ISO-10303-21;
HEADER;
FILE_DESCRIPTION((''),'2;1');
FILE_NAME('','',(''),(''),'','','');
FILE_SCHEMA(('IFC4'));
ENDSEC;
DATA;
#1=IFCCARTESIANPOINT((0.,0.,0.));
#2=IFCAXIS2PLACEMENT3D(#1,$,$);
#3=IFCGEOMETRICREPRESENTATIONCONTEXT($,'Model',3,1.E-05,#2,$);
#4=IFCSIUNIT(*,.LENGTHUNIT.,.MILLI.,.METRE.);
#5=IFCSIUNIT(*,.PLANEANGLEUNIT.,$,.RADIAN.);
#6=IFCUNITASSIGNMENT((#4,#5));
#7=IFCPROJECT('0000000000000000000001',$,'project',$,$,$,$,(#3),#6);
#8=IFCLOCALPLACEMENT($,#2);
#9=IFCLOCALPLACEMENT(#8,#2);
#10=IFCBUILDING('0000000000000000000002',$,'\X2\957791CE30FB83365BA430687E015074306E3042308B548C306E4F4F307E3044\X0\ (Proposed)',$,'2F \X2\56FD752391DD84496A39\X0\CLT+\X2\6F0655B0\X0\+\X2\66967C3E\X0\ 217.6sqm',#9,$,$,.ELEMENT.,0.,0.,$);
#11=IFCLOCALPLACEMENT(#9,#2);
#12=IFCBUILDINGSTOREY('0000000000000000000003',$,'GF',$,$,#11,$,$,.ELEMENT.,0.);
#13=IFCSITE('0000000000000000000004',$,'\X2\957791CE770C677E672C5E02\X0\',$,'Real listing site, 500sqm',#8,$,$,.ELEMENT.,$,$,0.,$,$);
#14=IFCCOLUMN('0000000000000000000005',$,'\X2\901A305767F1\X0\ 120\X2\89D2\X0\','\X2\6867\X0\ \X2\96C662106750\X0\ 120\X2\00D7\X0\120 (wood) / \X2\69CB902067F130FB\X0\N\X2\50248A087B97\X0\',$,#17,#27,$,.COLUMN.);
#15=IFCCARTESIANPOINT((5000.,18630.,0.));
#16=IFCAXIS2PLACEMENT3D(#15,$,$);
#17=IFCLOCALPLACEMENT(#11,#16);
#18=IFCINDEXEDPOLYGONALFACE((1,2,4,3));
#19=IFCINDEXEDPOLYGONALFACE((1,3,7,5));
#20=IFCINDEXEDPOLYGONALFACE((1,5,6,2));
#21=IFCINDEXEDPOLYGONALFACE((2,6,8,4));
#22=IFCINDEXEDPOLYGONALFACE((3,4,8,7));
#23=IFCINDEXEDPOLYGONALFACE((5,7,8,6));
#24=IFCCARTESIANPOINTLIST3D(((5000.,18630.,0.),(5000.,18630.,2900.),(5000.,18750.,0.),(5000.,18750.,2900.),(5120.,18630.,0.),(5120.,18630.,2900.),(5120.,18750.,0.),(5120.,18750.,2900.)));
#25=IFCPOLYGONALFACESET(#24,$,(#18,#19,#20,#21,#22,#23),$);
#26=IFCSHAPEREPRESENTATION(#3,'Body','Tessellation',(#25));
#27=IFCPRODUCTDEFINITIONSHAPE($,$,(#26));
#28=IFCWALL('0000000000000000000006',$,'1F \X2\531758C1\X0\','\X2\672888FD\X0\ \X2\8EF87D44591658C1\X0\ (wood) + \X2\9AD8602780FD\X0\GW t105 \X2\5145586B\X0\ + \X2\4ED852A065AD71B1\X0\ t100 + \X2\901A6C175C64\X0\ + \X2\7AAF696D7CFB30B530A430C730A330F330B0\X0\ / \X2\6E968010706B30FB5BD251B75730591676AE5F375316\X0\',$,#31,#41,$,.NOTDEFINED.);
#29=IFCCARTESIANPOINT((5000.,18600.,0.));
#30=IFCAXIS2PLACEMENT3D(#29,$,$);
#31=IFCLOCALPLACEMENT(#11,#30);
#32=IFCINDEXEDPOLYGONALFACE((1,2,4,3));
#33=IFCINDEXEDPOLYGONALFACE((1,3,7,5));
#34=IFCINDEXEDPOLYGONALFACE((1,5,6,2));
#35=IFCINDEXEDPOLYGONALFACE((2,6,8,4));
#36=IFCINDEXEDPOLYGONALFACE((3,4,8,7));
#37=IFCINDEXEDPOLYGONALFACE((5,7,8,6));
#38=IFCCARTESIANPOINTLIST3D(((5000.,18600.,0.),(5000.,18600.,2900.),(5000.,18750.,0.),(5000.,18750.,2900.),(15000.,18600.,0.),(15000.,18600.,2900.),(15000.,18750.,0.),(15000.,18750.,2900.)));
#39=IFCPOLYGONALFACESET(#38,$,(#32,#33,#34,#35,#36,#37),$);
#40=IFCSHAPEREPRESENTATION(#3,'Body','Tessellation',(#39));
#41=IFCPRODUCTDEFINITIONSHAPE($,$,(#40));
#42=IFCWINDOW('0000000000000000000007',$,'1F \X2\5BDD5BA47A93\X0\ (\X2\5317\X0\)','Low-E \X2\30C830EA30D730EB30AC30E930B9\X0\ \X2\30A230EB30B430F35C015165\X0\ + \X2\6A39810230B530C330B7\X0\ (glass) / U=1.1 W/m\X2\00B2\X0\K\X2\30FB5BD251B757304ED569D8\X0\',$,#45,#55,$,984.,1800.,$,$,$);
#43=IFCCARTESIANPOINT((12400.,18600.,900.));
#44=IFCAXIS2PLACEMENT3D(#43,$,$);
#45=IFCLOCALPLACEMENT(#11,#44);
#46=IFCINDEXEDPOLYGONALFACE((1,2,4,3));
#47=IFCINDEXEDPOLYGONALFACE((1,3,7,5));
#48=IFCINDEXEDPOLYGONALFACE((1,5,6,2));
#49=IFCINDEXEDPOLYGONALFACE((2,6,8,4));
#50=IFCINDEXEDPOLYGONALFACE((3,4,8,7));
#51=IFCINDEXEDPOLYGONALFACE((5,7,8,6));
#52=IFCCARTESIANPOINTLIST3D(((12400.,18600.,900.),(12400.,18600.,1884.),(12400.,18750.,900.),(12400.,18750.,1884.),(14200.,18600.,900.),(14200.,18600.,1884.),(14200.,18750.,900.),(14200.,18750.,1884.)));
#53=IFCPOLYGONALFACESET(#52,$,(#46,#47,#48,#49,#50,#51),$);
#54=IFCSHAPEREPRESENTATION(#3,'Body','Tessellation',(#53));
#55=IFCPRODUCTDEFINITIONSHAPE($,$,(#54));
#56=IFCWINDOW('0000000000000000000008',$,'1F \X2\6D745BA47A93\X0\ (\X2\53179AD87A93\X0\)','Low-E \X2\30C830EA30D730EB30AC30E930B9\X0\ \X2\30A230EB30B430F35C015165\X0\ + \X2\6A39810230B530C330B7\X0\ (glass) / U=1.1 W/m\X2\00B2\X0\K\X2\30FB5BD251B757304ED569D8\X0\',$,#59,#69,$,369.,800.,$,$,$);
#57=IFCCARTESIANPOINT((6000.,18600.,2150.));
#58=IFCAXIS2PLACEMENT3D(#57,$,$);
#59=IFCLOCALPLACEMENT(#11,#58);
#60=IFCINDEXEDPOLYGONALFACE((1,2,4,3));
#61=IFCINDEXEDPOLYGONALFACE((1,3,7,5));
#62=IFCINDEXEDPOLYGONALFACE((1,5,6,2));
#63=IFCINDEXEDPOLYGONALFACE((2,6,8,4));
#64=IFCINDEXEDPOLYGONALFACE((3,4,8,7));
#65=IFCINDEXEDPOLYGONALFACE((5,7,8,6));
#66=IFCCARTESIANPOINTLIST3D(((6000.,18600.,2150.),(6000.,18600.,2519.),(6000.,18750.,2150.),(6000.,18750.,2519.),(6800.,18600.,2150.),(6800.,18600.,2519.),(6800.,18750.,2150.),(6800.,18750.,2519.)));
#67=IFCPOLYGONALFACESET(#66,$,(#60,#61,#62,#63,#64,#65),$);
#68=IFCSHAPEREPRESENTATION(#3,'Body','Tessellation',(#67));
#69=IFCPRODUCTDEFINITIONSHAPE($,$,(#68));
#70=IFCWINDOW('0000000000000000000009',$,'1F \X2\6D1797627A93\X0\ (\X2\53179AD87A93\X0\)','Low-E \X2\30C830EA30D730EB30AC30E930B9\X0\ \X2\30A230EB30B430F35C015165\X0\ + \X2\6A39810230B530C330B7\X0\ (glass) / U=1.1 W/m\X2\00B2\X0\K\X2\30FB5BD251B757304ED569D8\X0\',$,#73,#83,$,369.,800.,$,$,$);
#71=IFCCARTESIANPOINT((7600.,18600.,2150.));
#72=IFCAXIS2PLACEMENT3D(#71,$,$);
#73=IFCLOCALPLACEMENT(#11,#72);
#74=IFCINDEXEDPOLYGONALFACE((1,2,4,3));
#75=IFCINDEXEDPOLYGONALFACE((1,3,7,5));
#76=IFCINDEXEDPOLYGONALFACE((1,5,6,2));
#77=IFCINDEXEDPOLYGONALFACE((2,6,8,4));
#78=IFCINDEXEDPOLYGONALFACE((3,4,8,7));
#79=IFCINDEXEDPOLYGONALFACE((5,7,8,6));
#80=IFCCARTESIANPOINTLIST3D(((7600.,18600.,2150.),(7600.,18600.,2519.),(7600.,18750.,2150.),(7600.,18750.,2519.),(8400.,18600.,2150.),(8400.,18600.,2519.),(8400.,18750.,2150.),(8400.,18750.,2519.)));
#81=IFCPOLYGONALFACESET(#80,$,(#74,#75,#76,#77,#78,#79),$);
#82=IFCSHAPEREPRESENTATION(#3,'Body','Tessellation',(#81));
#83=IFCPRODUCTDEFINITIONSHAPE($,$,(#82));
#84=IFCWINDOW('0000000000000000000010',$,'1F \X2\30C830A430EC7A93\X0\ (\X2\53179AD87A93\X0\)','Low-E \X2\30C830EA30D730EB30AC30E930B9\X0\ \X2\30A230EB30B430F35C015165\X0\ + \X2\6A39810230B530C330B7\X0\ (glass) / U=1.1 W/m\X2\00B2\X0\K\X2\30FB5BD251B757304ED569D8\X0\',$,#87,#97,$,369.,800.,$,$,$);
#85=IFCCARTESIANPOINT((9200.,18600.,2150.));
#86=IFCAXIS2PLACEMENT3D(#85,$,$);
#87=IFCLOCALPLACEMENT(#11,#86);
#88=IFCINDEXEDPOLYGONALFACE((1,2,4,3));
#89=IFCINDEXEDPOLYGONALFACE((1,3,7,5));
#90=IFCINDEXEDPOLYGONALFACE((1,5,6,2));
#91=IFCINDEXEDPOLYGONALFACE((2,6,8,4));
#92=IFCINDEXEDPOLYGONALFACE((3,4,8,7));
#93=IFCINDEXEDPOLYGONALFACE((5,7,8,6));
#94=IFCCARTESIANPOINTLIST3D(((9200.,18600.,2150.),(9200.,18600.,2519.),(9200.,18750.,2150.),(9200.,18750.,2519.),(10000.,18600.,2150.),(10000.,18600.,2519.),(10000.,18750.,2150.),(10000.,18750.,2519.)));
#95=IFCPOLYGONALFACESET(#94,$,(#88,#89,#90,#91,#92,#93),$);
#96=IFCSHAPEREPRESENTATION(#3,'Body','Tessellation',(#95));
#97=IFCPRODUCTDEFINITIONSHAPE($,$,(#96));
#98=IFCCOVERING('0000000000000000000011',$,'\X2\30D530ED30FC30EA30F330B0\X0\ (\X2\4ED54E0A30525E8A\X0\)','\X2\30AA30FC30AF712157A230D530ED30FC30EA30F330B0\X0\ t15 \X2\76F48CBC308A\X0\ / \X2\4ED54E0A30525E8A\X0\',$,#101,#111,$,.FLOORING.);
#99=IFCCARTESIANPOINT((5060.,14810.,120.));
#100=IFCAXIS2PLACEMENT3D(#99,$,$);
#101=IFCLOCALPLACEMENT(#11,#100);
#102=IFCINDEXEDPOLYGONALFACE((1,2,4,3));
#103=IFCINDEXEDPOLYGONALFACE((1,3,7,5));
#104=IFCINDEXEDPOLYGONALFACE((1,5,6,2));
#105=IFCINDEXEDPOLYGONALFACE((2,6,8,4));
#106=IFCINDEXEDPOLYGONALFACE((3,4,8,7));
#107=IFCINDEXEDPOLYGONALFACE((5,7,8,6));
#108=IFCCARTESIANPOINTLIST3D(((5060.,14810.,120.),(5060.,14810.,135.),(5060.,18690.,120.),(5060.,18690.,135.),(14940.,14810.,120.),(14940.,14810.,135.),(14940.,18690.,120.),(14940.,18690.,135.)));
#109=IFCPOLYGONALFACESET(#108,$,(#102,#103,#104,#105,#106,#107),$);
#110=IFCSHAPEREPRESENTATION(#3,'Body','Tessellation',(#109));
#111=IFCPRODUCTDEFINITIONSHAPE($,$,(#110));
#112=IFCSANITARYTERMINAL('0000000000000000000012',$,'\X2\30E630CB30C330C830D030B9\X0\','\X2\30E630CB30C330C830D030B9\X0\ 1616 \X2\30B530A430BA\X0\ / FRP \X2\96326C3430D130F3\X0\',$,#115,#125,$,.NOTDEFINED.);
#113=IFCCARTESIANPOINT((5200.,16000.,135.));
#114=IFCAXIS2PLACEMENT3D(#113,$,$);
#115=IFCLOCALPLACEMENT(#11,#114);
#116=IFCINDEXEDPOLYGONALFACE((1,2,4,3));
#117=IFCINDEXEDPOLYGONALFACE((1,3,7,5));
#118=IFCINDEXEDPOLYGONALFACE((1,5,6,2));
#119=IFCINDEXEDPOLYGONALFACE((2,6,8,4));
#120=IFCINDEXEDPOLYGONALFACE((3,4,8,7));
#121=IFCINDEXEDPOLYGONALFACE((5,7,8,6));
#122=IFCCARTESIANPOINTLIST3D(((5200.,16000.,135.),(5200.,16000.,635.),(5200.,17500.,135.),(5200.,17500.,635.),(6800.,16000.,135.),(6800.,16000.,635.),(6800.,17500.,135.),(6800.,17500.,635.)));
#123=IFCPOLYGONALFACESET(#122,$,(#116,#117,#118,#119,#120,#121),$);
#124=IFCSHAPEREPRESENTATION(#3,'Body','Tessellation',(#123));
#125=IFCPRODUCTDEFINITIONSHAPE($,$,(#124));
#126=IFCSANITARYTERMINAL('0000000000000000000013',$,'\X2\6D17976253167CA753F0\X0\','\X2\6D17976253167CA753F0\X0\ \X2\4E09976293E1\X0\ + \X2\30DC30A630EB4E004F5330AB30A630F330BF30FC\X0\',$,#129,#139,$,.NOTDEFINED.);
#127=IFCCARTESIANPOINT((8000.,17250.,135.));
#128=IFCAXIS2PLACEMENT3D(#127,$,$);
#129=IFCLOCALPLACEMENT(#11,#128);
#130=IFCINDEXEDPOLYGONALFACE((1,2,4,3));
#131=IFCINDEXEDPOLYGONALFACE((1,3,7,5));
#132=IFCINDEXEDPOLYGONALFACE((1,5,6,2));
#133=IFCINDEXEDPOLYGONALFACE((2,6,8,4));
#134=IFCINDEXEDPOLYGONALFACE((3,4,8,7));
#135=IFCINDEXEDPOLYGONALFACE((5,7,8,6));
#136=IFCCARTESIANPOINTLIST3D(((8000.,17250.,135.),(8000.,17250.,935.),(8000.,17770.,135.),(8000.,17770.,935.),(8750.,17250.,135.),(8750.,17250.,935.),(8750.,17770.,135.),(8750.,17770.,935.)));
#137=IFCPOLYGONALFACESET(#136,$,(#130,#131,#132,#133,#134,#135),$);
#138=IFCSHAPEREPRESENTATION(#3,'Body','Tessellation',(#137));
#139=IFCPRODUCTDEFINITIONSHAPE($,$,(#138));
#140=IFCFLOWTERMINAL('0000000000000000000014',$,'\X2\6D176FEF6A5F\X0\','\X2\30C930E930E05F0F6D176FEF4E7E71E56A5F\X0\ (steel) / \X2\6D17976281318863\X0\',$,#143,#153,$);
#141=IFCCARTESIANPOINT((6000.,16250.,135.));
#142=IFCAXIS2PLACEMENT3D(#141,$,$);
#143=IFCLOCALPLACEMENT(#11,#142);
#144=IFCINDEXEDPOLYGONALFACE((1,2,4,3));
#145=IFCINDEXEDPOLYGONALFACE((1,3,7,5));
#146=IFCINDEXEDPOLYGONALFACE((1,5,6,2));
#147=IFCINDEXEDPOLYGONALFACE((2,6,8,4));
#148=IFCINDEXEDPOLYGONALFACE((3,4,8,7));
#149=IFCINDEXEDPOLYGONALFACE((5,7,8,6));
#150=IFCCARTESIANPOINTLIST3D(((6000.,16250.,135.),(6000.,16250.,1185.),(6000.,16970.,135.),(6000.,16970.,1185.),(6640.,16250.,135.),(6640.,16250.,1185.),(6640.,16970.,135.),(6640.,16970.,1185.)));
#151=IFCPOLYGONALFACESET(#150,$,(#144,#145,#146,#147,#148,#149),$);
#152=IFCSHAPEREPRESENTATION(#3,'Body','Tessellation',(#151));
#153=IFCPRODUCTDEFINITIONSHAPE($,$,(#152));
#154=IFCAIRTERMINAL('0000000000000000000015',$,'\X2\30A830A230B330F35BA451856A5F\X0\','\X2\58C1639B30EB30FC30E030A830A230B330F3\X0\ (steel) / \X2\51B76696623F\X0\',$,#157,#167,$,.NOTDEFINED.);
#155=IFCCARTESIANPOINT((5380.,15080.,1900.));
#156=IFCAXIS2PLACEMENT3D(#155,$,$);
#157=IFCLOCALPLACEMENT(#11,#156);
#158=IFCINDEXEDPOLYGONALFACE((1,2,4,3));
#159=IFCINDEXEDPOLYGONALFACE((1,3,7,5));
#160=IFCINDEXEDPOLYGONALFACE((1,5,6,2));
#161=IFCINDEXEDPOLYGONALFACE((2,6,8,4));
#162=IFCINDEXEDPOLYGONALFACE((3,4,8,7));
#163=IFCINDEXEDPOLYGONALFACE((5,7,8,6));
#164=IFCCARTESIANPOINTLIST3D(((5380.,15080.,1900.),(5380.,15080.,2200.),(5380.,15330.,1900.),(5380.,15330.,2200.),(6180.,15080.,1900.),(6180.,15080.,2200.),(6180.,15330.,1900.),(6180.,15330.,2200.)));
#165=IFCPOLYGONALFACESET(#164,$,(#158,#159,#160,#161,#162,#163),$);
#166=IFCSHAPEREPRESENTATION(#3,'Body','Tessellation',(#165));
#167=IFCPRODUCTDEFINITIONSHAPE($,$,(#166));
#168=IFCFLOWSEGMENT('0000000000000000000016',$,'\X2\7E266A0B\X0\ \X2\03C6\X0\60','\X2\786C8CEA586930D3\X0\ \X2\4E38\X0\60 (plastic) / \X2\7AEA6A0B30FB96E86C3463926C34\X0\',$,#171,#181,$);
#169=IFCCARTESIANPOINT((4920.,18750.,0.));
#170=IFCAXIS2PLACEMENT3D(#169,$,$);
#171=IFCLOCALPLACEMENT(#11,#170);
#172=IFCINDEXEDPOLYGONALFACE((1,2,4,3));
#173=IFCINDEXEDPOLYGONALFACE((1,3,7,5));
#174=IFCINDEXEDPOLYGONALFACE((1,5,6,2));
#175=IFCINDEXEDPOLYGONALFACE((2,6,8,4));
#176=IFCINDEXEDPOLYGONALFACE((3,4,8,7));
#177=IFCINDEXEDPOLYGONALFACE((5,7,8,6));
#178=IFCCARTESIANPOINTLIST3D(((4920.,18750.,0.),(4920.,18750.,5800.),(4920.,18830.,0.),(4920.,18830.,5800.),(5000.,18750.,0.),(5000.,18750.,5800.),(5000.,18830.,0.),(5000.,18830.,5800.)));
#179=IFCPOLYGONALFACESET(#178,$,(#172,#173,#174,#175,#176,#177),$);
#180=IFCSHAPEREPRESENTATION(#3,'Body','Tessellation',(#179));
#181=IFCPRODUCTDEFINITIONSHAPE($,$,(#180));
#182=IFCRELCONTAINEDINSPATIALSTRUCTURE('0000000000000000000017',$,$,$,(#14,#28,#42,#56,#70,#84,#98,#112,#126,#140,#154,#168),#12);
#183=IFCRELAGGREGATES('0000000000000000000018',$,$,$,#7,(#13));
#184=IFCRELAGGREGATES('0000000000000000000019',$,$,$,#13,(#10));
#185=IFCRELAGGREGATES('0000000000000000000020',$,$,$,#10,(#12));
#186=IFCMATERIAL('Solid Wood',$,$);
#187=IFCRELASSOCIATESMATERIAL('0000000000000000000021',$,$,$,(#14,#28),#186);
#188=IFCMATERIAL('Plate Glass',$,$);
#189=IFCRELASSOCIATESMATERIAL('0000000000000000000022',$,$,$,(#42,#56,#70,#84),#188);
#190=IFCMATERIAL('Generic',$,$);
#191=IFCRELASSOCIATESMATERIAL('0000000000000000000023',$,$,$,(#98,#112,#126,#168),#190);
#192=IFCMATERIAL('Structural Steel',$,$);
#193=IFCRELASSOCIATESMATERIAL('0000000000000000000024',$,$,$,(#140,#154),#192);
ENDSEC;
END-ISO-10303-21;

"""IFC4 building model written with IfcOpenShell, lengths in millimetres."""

from ifc_helpers import new_model, si_unit, frame, frame_2d, origin, place, context, project, spatial, rectangle, extrude, material, element, fill, save


model = new_model("IFC4")

# Units and contexts
model_context = context("Model", 3, precision=1e-05, world=origin())
ifc_project = project(units=[si_unit("LENGTHUNIT", "METRE", prefix="MILLI"), si_unit("PLANEANGLEUNIT", "RADIAN")], contexts=[model_context])

# Site, building, storey
site_placement = place(None, origin())
site = spatial("IfcSite", under=ifc_project, at=site_placement, Name="長野県松本市", ObjectType="Real listing site, 500sqm", CompositionType="ELEMENT", RefElevation=0.0)
building_placement = place(site_placement, origin())
building = spatial("IfcBuilding", under=site, at=building_placement, Name="長野・茶室と縁側のある和の住まい (Proposed)", ObjectType="2F 国産針葉樹CLT+漆喰+暖簾 217.6sqm", CompositionType="ELEMENT", ElevationOfRefHeight=0.0, ElevationOfTerrain=0.0)
storey_placement = place(building_placement, origin())
storey = spatial("IfcBuildingStorey", under=building, at=storey_placement, Name="GF", CompositionType="ELEMENT", Elevation=0.0)

# Column
ifc_material_1 = material(Name="Solid Wood")
column_1_placement = place(storey_placement, frame((5000.0, 18630.0, 0.0)))
element("IfcColumn", 1, at=column_1_placement, inside=storey, material=ifc_material_1, Name="通し柱 120角", Description="桧 集成材 120×120 (wood) / 構造柱・N値計算", PredefinedType="COLUMN", context=model_context, shape_type="SweptSolid", body=[
    extrude(rectangle(XDim=120.0, YDim=120.0, at=frame_2d((60.0, 60.0))), frame((5000.0, 18630.0, 0.0)), (0.0, 0.0, 1.0), 2900.0),
])

# Wall, openings, windows
wall_1_placement = place(storey_placement, frame((5000.0, 18600.0, 0.0)))
wall_1 = element("IfcWall", 2, at=wall_1_placement, inside=storey, material=ifc_material_1, Name="1F 北壁", Description="木製 軸組外壁 (wood) + 高性能GW t105 充填 + 付加断熱 t100 + 通気層 + 窯業系サイディング / 準耐火・寒冷地外皮強化", PredefinedType="NOTDEFINED", context=model_context, shape_type="SweptSolid", body=[
    extrude(rectangle(XDim=10000.0, YDim=150.0, at=frame_2d((5000.0, 75.0))), frame((5000.0, 18600.0, 0.0)), (0.0, 0.0, 1.0), 2900.0),
])
opening_1_placement = place(storey_placement, frame((12400.0, 18600.0, 900.0)))
opening_1 = element("IfcOpeningElement", 3, at=opening_1_placement, cuts=wall_1, PredefinedType="NOTDEFINED", context=model_context, shape_type="SweptSolid", body=[
    extrude(rectangle(XDim=1800.0, YDim=150.0, at=frame_2d((900.0, 75.0))), frame((12400.0, 18600.0, 900.0)), (0.0, 0.0, 1.0), 984.0),
])
opening_2_placement = place(storey_placement, frame((6000.0, 18600.0, 2150.0)))
opening_2 = element("IfcOpeningElement", 4, at=opening_2_placement, cuts=wall_1, PredefinedType="NOTDEFINED", context=model_context, shape_type="SweptSolid", body=[
    extrude(rectangle(XDim=800.0, YDim=150.0, at=frame_2d((400.0, 75.0))), frame((6000.0, 18600.0, 2150.0)), (0.0, 0.0, 1.0), 369.0),
])
opening_3_placement = place(storey_placement, frame((7600.0, 18600.0, 2150.0)))
opening_3 = element("IfcOpeningElement", 5, at=opening_3_placement, cuts=wall_1, PredefinedType="NOTDEFINED", context=model_context, shape_type="SweptSolid", body=[
    extrude(rectangle(XDim=800.0, YDim=150.0, at=frame_2d((400.0, 75.0))), frame((7600.0, 18600.0, 2150.0)), (0.0, 0.0, 1.0), 369.0),
])
opening_4_placement = place(storey_placement, frame((9200.0, 18600.0, 2150.0)))
opening_4 = element("IfcOpeningElement", 6, at=opening_4_placement, cuts=wall_1, PredefinedType="NOTDEFINED", context=model_context, shape_type="SweptSolid", body=[
    extrude(rectangle(XDim=800.0, YDim=150.0, at=frame_2d((400.0, 75.0))), frame((9200.0, 18600.0, 2150.0)), (0.0, 0.0, 1.0), 369.0),
])
ifc_material_2 = material(Name="Plate Glass")
window_1_placement = place(storey_placement, frame((12400.0, 18600.0, 900.0)))
window_1 = element("IfcWindow", 7, at=window_1_placement, inside=storey, material=ifc_material_2, Name="1F 寝室窓 (北)", Description="Low-E トリプルガラス アルゴン封入 + 樹脂サッシ (glass) / U=1.1 W/m²K・寒冷地仕様", OverallHeight=984.0, OverallWidth=1800.0, context=model_context, shape_type="SweptSolid", body=[
    extrude(rectangle(XDim=1800.0, YDim=150.0, at=frame_2d((900.0, 75.0))), frame((12400.0, 18600.0, 900.0)), (0.0, 0.0, 1.0), 984.0),
])
fill(opening_1, window_1)
window_2_placement = place(storey_placement, frame((6000.0, 18600.0, 2150.0)))
window_2 = element("IfcWindow", 8, at=window_2_placement, inside=storey, material=ifc_material_2, Name="1F 浴室窓 (北高窓)", Description="Low-E トリプルガラス アルゴン封入 + 樹脂サッシ (glass) / U=1.1 W/m²K・寒冷地仕様", OverallHeight=369.0, OverallWidth=800.0, context=model_context, shape_type="SweptSolid", body=[
    extrude(rectangle(XDim=800.0, YDim=150.0, at=frame_2d((400.0, 75.0))), frame((6000.0, 18600.0, 2150.0)), (0.0, 0.0, 1.0), 369.0),
])
fill(opening_2, window_2)
window_3_placement = place(storey_placement, frame((7600.0, 18600.0, 2150.0)))
window_3 = element("IfcWindow", 9, at=window_3_placement, inside=storey, material=ifc_material_2, Name="1F 洗面窓 (北高窓)", Description="Low-E トリプルガラス アルゴン封入 + 樹脂サッシ (glass) / U=1.1 W/m²K・寒冷地仕様", OverallHeight=369.0, OverallWidth=800.0, context=model_context, shape_type="SweptSolid", body=[
    extrude(rectangle(XDim=800.0, YDim=150.0, at=frame_2d((400.0, 75.0))), frame((7600.0, 18600.0, 2150.0)), (0.0, 0.0, 1.0), 369.0),
])
fill(opening_3, window_3)
window_4_placement = place(storey_placement, frame((9200.0, 18600.0, 2150.0)))
window_4 = element("IfcWindow", 10, at=window_4_placement, inside=storey, material=ifc_material_2, Name="1F トイレ窓 (北高窓)", Description="Low-E トリプルガラス アルゴン封入 + 樹脂サッシ (glass) / U=1.1 W/m²K・寒冷地仕様", OverallHeight=369.0, OverallWidth=800.0, context=model_context, shape_type="SweptSolid", body=[
    extrude(rectangle(XDim=800.0, YDim=150.0, at=frame_2d((400.0, 75.0))), frame((9200.0, 18600.0, 2150.0)), (0.0, 0.0, 1.0), 369.0),
])
fill(opening_4, window_4)

# Covering
ifc_material_3 = material(Name="Generic")
covering_placement = place(storey_placement, frame((5060.0, 14810.0, 120.0)))
element("IfcCovering", 11, at=covering_placement, inside=storey, material=ifc_material_3, Name="フローリング (仕上げ床)", Description="オーク無垢フローリング t15 直貼り / 仕上げ床", PredefinedType="FLOORING", context=model_context, shape_type="SweptSolid", body=[
    extrude(rectangle(XDim=9880.0, YDim=3880.0, at=frame_2d((4940.0, 1940.0))), frame((5060.0, 14810.0, 120.0)), (0.0, 0.0, 1.0), 15.0),
])

# Sanitary terminals
sanitary_terminal_1_placement = place(storey_placement, frame((5200.0, 16000.0, 135.0)))
element("IfcSanitaryTerminal", 12, at=sanitary_terminal_1_placement, inside=storey, material=ifc_material_3, Name="ユニットバス", Description="ユニットバス 1616 サイズ / FRP 防水パン", PredefinedType="NOTDEFINED", context=model_context, shape_type="SweptSolid", body=[
    extrude(rectangle(XDim=1600.0, YDim=1500.0, at=frame_2d((800.0, 750.0))), frame((5200.0, 16000.0, 135.0)), (0.0, 0.0, 1.0), 500.0),
])
sanitary_terminal_2_placement = place(storey_placement, frame((8000.0, 17250.0, 135.0)))
element("IfcSanitaryTerminal", 13, at=sanitary_terminal_2_placement, inside=storey, material=ifc_material_3, Name="洗面化粧台", Description="洗面化粧台 三面鏡 + ボウル一体カウンター", PredefinedType="NOTDEFINED", context=model_context, shape_type="SweptSolid", body=[
    extrude(rectangle(XDim=750.0, YDim=520.0, at=frame_2d((375.0, 260.0))), frame((8000.0, 17250.0, 135.0)), (0.0, 0.0, 1.0), 800.0),
])

# Flow terminal
ifc_material_4 = material(Name="Structural Steel")
flow_terminal_placement = place(storey_placement, frame((6000.0, 16250.0, 135.0)))
element("IfcFlowTerminal", 14, at=flow_terminal_placement, inside=storey, material=ifc_material_4, Name="洗濯機", Description="ドラム式洗濯乾燥機 (steel) / 洗面脱衣", context=model_context, shape_type="SweptSolid", body=[
    extrude(rectangle(XDim=640.0, YDim=720.0, at=frame_2d((320.0, 360.0))), frame((6000.0, 16250.0, 135.0)), (0.0, 0.0, 1.0), 1050.0),
])

# Air terminal
air_terminal_placement = place(storey_placement, frame((5380.0, 15080.0, 1900.0)))
element("IfcAirTerminal", 15, at=air_terminal_placement, inside=storey, material=ifc_material_4, Name="エアコン室内機", Description="壁掛ルームエアコン (steel) / 冷暖房", PredefinedType="NOTDEFINED", context=model_context, shape_type="SweptSolid", body=[
    extrude(rectangle(XDim=800.0, YDim=250.0, at=frame_2d((400.0, 125.0))), frame((5380.0, 15080.0, 1900.0)), (0.0, 0.0, 1.0), 300.0),
])

# Flow segment
flow_segment_placement = place(storey_placement, frame((4920.0, 18750.0, 0.0)))
element("IfcFlowSegment", 16, at=flow_segment_placement, inside=storey, material=ifc_material_3, Name="縦樋 φ60", Description="硬質塩ビ 丸60 (plastic) / 竪樋・雨水排水", context=model_context, shape_type="SweptSolid", body=[
    extrude(rectangle(XDim=80.0, YDim=80.0, at=frame_2d((40.0, 40.0))), frame((4920.0, 18750.0, 0.0)), (0.0, 0.0, 1.0), 5800.0),
])

save(model, "model.ifc")
